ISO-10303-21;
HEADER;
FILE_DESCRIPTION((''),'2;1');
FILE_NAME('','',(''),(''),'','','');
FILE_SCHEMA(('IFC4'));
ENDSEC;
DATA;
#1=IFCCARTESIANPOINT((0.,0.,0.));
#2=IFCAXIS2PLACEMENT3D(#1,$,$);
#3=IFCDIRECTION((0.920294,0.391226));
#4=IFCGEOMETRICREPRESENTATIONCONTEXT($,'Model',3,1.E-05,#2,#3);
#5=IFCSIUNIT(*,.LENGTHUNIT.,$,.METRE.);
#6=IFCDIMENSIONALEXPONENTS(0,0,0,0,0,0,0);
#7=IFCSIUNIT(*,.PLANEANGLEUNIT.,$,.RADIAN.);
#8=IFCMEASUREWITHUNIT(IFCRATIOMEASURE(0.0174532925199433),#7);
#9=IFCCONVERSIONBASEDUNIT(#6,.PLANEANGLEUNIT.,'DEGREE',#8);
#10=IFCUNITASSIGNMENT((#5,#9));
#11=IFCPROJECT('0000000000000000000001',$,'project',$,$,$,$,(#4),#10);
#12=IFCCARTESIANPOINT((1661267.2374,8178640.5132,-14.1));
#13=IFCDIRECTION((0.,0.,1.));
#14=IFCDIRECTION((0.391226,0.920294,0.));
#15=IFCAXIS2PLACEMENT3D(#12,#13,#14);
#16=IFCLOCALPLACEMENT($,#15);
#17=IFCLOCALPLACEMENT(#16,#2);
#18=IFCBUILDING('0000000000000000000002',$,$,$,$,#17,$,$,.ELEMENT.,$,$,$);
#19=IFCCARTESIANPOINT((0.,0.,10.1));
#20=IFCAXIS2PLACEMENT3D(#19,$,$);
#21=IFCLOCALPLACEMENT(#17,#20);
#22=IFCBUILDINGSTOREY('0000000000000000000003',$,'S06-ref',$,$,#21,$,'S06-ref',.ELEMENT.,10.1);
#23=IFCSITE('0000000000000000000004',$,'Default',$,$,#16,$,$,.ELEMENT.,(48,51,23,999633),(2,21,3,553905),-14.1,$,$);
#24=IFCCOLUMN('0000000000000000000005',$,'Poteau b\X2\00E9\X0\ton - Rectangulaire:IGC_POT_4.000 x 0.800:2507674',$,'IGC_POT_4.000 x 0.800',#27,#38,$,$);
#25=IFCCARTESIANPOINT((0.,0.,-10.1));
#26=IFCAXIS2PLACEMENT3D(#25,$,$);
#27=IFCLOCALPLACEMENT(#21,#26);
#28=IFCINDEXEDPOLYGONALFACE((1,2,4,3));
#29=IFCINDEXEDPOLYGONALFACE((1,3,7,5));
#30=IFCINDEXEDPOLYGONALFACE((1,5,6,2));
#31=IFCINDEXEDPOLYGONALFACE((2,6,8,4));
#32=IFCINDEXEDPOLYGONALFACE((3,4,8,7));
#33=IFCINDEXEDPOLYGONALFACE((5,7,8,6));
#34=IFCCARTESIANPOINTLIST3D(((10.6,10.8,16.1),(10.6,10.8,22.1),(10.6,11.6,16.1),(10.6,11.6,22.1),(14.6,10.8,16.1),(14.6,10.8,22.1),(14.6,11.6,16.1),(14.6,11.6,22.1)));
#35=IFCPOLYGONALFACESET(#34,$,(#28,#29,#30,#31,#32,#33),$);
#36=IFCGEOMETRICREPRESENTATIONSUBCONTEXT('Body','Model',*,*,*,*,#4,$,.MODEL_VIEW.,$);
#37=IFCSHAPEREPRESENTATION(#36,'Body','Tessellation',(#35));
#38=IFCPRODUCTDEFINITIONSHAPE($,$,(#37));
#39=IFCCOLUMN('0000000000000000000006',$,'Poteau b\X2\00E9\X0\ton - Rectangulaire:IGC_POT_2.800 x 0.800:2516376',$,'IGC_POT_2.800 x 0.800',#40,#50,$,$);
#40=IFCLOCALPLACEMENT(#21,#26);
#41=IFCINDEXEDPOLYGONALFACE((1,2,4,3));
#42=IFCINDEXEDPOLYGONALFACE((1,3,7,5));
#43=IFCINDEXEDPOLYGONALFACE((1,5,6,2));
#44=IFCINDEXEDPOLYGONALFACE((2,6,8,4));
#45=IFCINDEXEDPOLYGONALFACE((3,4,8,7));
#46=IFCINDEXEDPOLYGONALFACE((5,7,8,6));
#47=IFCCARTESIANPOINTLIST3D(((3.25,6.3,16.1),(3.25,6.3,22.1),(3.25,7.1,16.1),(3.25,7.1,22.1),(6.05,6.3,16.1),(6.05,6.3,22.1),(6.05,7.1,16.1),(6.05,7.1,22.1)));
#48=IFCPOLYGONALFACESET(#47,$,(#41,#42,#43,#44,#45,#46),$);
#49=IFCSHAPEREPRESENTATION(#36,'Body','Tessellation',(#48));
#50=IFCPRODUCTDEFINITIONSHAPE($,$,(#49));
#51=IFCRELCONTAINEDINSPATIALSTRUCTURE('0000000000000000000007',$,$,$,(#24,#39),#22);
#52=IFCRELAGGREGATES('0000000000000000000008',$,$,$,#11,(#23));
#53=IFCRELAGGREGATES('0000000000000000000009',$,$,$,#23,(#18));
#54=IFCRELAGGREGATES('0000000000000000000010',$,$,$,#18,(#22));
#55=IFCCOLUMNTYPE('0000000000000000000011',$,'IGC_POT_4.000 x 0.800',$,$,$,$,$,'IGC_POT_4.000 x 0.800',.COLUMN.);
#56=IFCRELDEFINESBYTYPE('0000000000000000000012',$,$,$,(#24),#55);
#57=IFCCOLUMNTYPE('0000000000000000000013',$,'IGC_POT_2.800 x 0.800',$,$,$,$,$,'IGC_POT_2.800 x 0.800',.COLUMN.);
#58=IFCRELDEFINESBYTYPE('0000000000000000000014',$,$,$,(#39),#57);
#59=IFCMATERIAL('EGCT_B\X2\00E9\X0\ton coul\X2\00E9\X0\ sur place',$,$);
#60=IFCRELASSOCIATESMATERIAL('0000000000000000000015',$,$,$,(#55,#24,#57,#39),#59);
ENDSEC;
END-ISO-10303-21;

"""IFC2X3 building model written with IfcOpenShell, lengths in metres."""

from ifc_helpers import new_model, entity, si_unit, converted_unit, direction, frame, frame_2d, origin, origin_2d_with_axis, place, context, subcontext, project, spatial, rectangle, extrude, source, transform, mapped, material, type_object, type_shapes, element, save


model = new_model("IFC2X3")

# Units and contexts
model_context = context("Model", 3, precision=1e-05, world=origin(), true_north=direction((0.920294, 0.391226)))
body_context = subcontext(model_context, "Body", "Model", "MODEL_VIEW")
ifc_project = project(units=[si_unit("LENGTHUNIT", "METRE"), converted_unit("PLANEANGLEUNIT", "DEGREE", entity("IfcRatioMeasure", 0.0174532925199433), si_unit("PLANEANGLEUNIT", "RADIAN"), dimensions=[0, 0, 0, 0, 0, 0, 0])], contexts=[model_context])

# Site, building, storey
site_placement = place(None, frame((1661267.2374, 8178640.5132, -14.1), z_axis=(0.0, 0.0, 1.0), x_axis=(0.391226, 0.920294, 0.0)))
site = spatial("IfcSite", under=ifc_project, at=site_placement, Name="Default", CompositionType="ELEMENT", RefLatitude=(48, 51, 23, 999633), RefLongitude=(2, 21, 3, 553905), RefElevation=-14.1)
building_placement = place(site_placement, origin())
building = spatial("IfcBuilding", under=site, at=building_placement, CompositionType="ELEMENT")
storey_placement = place(building_placement, frame((0.0, 0.0, 10.1)))
storey = spatial("IfcBuildingStorey", under=building, at=storey_placement, Name="S06-ref", LongName="S06-ref", CompositionType="ELEMENT", Elevation=10.1)

# Columns
ifc_material_1 = material(Name="EGCT_Béton coulé sur place")
column_type_1 = type_object("IfcColumnType", Name="IGC_POT_4.000 x 0.800", ElementType="IGC_POT_4.000 x 0.800", PredefinedType="COLUMN", material=ifc_material_1)
shared_shape_1 = source(origin(), body_context, "Body", "SweptSolid", [
    extrude(rectangle(XDim=0.8, YDim=4.0, at=origin_2d_with_axis()), frame((12.6, 11.2, 16.1), z_axis=(0.0, 0.0, 1.0), x_axis=(0.0, -1.0, 0.0)), (0.0, 0.0, 1.0), 6.0),
])
type_shapes(column_type_1, [shared_shape_1])
column_1_placement = place(storey_placement, frame((0.0, 0.0, -10.1)))
element("IfcColumn", 1, at=column_1_placement, inside=storey, type_object=column_type_1, material=ifc_material_1, Name="Poteau béton - Rectangulaire:IGC_POT_4.000 x 0.800:2507674", ObjectType="IGC_POT_4.000 x 0.800", context=body_context, shape_type="MappedRepresentation", body=[
    mapped(shared_shape_1, transform((0.0, 0.0, 0.0), scale=1.0)),
])
column_type_2 = type_object("IfcColumnType", Name="IGC_POT_2.800 x 0.800", ElementType="IGC_POT_2.800 x 0.800", PredefinedType="COLUMN", material=ifc_material_1)
shared_shape_2 = source(origin(), body_context, "Body", "SweptSolid", [
    extrude(rectangle(XDim=0.8, YDim=2.8, at=frame_2d((0.0, 0.0), x_axis=(1.0, 0.0))), frame((4.65, 6.7, 16.1), z_axis=(0.0, 0.0, 1.0), x_axis=(0.0, -1.0, 0.0)), (0.0, 0.0, 1.0), 6.0),
])
type_shapes(column_type_2, [shared_shape_2])
column_2_placement = place(storey_placement, frame((0.0, 0.0, -10.1)))
element("IfcColumn", 2, at=column_2_placement, inside=storey, type_object=column_type_2, material=ifc_material_1, Name="Poteau béton - Rectangulaire:IGC_POT_2.800 x 0.800:2516376", ObjectType="IGC_POT_2.800 x 0.800", context=body_context, shape_type="MappedRepresentation", body=[
    mapped(shared_shape_2, transform((0.0, 0.0, 0.0), scale=1.0)),
])

save(model, "model.ifc")
